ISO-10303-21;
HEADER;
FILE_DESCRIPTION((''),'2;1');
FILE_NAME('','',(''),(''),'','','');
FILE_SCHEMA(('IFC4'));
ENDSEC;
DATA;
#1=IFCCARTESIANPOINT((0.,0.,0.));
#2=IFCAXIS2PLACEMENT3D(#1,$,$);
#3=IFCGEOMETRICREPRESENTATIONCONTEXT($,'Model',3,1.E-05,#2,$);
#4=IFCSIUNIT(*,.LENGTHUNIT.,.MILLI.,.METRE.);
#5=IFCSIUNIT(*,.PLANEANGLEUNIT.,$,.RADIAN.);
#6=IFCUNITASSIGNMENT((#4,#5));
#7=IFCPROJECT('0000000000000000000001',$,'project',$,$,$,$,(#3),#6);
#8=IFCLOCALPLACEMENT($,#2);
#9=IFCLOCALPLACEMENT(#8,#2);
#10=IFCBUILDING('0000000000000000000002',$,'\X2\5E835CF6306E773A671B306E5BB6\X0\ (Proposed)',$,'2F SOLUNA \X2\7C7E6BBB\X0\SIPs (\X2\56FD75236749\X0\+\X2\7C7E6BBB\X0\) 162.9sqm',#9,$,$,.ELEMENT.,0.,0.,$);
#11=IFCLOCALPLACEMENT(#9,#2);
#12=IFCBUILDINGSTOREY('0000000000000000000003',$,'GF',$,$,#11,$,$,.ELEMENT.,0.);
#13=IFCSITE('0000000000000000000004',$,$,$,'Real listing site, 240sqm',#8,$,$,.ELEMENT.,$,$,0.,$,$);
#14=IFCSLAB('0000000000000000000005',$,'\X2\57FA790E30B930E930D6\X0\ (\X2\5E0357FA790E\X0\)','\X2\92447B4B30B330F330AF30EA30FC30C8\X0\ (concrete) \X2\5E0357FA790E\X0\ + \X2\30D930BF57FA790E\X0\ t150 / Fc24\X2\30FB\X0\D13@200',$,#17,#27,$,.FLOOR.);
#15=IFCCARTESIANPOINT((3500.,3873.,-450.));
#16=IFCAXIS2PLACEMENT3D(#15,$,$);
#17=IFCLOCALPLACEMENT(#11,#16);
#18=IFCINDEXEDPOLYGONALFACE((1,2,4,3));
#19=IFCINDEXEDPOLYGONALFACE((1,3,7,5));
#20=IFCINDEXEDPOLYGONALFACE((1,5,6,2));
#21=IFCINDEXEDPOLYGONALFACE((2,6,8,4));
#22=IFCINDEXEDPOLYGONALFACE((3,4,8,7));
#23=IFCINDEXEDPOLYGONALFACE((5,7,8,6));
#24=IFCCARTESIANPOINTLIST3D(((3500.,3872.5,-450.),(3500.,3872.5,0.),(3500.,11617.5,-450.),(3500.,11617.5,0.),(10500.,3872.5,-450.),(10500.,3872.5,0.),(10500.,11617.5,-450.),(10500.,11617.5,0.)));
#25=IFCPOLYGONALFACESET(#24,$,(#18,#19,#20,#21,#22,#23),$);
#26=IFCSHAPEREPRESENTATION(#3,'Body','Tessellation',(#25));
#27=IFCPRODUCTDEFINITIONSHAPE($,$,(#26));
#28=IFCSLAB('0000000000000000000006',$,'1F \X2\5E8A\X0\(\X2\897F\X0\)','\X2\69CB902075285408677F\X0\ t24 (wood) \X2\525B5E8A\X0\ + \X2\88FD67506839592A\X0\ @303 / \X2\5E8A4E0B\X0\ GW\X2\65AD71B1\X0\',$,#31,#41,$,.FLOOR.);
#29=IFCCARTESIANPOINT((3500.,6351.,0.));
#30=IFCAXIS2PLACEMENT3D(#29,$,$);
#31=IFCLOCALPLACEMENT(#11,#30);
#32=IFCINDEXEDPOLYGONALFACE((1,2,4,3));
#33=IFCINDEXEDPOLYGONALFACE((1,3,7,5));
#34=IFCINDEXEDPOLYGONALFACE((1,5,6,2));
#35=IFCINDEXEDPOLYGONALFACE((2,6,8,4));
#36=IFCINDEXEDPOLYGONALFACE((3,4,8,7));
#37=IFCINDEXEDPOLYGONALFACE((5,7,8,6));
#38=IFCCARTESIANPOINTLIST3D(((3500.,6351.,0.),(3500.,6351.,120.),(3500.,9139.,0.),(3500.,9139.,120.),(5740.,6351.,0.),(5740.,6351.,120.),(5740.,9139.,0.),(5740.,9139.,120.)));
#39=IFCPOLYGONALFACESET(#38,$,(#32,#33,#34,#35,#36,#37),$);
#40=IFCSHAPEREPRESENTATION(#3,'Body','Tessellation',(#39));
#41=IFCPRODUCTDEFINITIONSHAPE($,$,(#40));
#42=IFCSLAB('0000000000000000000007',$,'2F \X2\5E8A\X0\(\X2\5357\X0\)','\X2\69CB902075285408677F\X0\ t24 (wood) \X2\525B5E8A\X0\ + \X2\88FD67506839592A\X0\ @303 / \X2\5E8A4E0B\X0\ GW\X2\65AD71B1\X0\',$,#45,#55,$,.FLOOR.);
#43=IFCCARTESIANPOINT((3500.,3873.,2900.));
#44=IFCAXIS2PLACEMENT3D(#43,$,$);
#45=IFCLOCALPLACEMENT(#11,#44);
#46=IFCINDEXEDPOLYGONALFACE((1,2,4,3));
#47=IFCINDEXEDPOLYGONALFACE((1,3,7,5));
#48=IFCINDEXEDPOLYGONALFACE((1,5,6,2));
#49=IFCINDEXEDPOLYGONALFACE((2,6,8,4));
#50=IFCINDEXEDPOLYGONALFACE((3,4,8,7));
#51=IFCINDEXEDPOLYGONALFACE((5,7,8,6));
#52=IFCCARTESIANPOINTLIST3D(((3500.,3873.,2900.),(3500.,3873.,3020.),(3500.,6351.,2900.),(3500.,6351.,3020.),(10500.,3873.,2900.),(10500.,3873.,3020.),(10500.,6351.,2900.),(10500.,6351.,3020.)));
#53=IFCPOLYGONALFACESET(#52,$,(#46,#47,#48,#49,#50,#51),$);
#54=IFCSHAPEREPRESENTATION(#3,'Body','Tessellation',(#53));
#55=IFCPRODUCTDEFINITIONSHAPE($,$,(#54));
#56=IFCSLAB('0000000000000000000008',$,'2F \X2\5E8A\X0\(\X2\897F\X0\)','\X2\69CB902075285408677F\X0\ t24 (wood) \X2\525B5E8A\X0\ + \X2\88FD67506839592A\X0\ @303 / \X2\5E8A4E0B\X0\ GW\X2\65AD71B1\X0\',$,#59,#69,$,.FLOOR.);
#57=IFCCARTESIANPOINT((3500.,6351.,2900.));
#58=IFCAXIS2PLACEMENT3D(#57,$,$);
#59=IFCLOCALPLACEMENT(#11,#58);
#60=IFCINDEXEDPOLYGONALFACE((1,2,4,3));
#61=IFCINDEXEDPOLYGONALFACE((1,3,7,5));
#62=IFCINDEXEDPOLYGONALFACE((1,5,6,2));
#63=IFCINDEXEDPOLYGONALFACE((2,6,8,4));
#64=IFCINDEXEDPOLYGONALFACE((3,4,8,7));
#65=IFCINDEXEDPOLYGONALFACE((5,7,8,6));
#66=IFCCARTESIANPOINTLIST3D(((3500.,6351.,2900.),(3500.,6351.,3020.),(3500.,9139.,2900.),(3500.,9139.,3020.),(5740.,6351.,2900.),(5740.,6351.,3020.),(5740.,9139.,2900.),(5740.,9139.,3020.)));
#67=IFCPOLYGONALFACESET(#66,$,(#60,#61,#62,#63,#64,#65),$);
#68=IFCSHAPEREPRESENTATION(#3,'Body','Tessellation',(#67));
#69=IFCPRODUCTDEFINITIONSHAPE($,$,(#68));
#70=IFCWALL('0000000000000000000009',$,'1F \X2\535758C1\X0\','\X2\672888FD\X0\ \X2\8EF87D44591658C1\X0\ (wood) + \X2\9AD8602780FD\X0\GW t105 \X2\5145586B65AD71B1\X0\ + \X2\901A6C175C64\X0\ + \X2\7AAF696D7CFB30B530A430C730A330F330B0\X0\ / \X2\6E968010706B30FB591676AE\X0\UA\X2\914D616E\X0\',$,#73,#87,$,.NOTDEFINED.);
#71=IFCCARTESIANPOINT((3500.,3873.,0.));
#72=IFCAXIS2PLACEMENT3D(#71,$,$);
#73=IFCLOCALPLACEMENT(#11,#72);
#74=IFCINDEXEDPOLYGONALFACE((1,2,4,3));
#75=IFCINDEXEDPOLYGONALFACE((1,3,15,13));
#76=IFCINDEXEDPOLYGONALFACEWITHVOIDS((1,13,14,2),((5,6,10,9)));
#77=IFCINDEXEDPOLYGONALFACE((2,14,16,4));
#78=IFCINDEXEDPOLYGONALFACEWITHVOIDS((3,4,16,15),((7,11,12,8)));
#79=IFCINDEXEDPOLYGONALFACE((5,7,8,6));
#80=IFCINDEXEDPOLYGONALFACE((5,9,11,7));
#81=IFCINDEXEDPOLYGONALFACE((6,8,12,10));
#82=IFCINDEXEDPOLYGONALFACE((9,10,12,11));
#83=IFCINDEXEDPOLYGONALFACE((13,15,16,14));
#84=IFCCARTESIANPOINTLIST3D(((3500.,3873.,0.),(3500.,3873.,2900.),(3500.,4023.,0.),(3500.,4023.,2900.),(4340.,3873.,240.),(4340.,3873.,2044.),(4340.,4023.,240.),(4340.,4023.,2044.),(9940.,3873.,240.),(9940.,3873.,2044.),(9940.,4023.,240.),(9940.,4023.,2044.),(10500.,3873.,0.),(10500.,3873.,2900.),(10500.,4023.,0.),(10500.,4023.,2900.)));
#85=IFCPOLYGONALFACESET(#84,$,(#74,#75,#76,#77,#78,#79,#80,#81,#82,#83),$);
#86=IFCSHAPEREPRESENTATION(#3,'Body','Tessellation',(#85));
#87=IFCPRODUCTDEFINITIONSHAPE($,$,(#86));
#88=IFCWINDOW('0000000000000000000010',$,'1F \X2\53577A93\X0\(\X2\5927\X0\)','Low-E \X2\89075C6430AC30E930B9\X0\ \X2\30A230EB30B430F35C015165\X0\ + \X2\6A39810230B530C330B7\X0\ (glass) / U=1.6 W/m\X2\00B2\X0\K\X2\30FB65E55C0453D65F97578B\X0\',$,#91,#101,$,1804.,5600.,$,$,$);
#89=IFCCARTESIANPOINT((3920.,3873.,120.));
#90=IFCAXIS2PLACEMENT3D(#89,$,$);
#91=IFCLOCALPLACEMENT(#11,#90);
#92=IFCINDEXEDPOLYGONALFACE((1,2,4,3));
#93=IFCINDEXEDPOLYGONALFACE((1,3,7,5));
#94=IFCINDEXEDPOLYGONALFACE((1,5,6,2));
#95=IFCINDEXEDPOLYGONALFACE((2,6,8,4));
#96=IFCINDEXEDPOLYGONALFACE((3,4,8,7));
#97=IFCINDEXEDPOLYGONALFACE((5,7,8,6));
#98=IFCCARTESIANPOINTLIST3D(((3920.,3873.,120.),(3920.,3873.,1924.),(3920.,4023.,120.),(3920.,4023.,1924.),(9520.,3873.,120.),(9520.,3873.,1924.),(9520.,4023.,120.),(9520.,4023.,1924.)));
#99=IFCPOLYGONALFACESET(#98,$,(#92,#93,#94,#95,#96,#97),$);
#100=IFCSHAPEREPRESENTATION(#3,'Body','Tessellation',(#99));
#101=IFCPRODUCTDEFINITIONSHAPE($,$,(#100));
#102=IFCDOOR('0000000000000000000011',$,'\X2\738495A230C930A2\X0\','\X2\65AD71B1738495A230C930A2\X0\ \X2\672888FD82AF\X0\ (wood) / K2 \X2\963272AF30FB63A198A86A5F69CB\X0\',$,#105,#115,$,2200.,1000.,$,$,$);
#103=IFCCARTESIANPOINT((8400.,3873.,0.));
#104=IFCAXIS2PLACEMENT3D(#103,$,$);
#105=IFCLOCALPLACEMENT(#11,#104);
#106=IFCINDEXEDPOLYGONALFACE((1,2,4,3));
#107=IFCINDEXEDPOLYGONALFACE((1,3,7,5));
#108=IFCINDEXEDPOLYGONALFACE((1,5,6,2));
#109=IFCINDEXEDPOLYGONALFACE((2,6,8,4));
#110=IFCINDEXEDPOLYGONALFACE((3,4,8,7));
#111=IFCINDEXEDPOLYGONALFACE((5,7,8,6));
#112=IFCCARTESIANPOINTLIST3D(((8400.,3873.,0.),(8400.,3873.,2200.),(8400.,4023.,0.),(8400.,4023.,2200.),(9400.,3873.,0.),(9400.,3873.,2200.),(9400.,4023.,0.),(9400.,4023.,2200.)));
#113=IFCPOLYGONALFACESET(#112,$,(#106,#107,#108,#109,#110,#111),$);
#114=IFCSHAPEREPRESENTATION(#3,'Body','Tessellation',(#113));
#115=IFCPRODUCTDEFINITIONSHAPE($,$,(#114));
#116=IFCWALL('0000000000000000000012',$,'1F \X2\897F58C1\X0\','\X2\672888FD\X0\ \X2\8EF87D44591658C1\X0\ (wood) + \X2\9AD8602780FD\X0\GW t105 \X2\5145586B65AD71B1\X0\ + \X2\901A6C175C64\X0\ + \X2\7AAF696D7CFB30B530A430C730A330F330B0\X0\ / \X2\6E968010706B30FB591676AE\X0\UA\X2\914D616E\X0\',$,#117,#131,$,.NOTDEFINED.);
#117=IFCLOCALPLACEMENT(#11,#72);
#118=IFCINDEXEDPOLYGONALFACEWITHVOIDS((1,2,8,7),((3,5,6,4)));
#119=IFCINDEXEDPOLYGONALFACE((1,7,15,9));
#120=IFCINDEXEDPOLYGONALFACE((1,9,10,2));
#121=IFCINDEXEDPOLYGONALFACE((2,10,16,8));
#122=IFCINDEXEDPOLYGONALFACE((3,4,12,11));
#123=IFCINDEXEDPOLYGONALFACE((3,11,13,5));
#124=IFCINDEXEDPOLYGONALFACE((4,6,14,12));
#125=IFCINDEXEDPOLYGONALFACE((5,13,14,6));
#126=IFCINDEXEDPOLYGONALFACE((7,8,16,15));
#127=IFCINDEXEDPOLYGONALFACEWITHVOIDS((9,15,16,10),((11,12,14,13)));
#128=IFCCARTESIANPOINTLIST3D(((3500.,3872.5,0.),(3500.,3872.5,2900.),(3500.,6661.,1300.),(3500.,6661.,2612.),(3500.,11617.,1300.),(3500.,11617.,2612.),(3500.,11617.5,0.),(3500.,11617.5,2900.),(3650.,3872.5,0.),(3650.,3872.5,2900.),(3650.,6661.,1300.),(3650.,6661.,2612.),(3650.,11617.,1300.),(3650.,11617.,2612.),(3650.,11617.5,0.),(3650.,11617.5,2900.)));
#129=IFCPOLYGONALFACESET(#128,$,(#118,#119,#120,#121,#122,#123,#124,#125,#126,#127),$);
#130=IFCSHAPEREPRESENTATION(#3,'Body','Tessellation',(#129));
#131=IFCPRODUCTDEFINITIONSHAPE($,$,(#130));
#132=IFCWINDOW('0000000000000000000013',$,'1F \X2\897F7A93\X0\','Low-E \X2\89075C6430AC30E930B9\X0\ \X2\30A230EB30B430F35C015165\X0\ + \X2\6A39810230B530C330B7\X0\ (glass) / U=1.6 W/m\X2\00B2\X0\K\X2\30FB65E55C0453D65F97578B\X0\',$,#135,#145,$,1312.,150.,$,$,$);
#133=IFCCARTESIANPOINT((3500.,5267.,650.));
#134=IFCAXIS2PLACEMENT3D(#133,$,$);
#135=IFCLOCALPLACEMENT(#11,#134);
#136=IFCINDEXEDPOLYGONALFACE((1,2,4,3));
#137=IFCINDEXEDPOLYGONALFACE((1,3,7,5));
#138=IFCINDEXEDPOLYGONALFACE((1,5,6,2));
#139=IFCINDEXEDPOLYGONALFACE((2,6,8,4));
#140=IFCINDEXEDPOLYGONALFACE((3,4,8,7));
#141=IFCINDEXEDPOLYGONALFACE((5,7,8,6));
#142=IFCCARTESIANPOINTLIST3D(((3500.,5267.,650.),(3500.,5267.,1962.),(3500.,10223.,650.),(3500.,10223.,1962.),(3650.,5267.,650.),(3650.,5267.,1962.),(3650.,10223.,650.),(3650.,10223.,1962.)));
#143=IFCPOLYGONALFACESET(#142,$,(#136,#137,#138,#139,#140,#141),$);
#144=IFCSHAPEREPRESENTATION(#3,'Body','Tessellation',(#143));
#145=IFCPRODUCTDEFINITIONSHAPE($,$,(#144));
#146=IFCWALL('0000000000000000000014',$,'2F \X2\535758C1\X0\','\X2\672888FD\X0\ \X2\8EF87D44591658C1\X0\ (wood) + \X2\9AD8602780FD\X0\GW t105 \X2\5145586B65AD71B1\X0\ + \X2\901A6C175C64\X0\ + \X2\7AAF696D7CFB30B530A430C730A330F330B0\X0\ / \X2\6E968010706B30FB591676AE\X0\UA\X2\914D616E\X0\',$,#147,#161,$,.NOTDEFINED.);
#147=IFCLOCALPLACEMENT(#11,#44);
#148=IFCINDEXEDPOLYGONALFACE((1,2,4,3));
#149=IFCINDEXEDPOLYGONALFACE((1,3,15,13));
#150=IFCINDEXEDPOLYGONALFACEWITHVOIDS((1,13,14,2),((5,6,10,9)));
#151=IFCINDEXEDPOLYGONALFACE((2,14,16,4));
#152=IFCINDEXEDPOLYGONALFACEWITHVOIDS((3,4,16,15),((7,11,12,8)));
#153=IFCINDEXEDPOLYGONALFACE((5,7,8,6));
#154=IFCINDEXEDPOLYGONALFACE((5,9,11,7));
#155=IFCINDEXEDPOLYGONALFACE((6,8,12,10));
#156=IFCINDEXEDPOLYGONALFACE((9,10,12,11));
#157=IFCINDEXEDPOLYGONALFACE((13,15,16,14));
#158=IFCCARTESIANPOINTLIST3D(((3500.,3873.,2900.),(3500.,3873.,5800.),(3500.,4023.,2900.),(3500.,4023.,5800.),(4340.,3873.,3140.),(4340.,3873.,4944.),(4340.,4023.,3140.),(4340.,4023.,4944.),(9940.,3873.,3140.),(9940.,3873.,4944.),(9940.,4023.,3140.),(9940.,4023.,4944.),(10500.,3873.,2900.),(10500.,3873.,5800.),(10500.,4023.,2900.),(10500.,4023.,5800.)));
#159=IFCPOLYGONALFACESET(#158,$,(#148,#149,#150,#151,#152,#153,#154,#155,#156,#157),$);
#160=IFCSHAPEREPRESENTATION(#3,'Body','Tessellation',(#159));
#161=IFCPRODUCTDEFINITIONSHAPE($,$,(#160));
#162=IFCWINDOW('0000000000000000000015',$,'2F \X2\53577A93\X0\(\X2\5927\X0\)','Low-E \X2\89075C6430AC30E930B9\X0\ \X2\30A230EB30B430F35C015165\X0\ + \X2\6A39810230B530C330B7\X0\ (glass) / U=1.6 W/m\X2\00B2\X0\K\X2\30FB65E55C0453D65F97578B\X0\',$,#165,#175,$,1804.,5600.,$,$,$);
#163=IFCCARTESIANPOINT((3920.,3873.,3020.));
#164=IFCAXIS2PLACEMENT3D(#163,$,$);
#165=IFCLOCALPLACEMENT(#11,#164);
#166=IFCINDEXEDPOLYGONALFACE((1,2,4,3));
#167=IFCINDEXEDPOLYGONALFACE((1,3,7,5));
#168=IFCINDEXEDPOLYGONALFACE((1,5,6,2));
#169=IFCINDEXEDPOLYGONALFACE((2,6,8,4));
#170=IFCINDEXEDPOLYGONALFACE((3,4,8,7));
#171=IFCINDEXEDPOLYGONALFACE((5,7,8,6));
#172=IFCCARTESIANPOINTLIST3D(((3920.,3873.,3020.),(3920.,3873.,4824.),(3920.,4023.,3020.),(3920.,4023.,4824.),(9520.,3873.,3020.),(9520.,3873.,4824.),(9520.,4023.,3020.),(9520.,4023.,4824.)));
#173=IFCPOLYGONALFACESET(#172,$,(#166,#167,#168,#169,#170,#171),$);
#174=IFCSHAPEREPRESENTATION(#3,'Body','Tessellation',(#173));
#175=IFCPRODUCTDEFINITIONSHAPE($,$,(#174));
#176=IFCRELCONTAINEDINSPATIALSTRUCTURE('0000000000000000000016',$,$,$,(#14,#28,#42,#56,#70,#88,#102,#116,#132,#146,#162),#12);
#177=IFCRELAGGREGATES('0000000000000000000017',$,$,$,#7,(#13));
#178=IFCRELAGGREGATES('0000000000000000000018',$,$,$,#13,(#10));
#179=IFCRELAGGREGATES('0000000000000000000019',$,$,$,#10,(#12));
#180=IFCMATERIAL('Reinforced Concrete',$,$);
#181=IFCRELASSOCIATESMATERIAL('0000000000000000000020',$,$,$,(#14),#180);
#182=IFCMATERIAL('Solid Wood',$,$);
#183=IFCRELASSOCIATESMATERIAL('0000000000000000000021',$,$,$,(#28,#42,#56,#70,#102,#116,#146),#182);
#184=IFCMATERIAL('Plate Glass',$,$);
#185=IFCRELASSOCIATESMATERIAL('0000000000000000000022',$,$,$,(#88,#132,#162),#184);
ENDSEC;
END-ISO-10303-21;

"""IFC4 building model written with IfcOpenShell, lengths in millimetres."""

from ifc_helpers import new_model, si_unit, frame, frame_2d, origin, place, context, project, spatial, rectangle, extrude, material, element, fill, save


model = new_model("IFC4")

# Units and contexts
model_context = context("Model", 3, precision=1e-05, world=origin())
ifc_project = project(units=[si_unit("LENGTHUNIT", "METRE", prefix="MILLI"), si_unit("PLANEANGLEUNIT", "RADIAN")], contexts=[model_context])

# Site, building, storey
site_placement = place(None, origin())
site = spatial("IfcSite", under=ifc_project, at=site_placement, ObjectType="Real listing site, 240sqm", CompositionType="ELEMENT", RefElevation=0.0)
building_placement = place(site_placement, origin())
building = spatial("IfcBuilding", under=site, at=building_placement, Name="広島の眺望の家 (Proposed)", ObjectType="2F SOLUNA 籾殻SIPs (国産杉+籾殻) 162.9sqm", CompositionType="ELEMENT", ElevationOfRefHeight=0.0, ElevationOfTerrain=0.0)
storey_placement = place(building_placement, origin())
storey = spatial("IfcBuildingStorey", under=building, at=storey_placement, Name="GF", CompositionType="ELEMENT", Elevation=0.0)

# Slabs
ifc_material_1 = material(Name="Reinforced Concrete")
slab_1_placement = place(storey_placement, frame((3500.0, 3873.0, -450.0)))
element("IfcSlab", 1, at=slab_1_placement, inside=storey, material=ifc_material_1, Name="基礎スラブ (布基礎)", Description="鉄筋コンクリート (concrete) 布基礎 + ベタ基礎 t150 / Fc24・D13@200", PredefinedType="FLOOR", context=model_context, shape_type="SweptSolid", body=[
    extrude(rectangle(XDim=7000.0, YDim=7745.0, at=frame_2d((3500.0, 3872.0))), frame((3500.0, 3873.0, -450.0)), (0.0, 0.0, 1.0), 450.0),
])
ifc_material_2 = material(Name="Solid Wood")
slab_2_placement = place(storey_placement, frame((3500.0, 6351.0, 0.0)))
element("IfcSlab", 2, at=slab_2_placement, inside=storey, material=ifc_material_2, Name="1F 床(西)", Description="構造用合板 t24 (wood) 剛床 + 製材根太 @303 / 床下 GW断熱", PredefinedType="FLOOR", context=model_context, shape_type="SweptSolid", body=[
    extrude(rectangle(XDim=2240.0, YDim=2788.0, at=frame_2d((1120.0, 1394.0))), frame((3500.0, 6351.0, 0.0)), (0.0, 0.0, 1.0), 120.0),
])
slab_3_placement = place(storey_placement, frame((3500.0, 3873.0, 2900.0)))
element("IfcSlab", 3, at=slab_3_placement, inside=storey, material=ifc_material_2, Name="2F 床(南)", Description="構造用合板 t24 (wood) 剛床 + 製材根太 @303 / 床下 GW断熱", PredefinedType="FLOOR", context=model_context, shape_type="SweptSolid", body=[
    extrude(rectangle(XDim=7000.0, YDim=2478.0, at=frame_2d((3500.0, 1239.0))), frame((3500.0, 3873.0, 2900.0)), (0.0, 0.0, 1.0), 120.0),
])
slab_4_placement = place(storey_placement, frame((3500.0, 6351.0, 2900.0)))
element("IfcSlab", 4, at=slab_4_placement, inside=storey, material=ifc_material_2, Name="2F 床(西)", Description="構造用合板 t24 (wood) 剛床 + 製材根太 @303 / 床下 GW断熱", PredefinedType="FLOOR", context=model_context, shape_type="SweptSolid", body=[
    extrude(rectangle(XDim=2240.0, YDim=2788.0, at=frame_2d((1120.0, 1394.0))), frame((3500.0, 6351.0, 2900.0)), (0.0, 0.0, 1.0), 120.0),
])

# Wall, openings, window, door
wall_1_placement = place(storey_placement, frame((3500.0, 3873.0, 0.0)))
wall_1 = element("IfcWall", 5, at=wall_1_placement, inside=storey, material=ifc_material_2, Name="1F 南壁", Description="木製 軸組外壁 (wood) + 高性能GW t105 充填断熱 + 通気層 + 窯業系サイディング / 準耐火・外皮UA配慮", PredefinedType="NOTDEFINED", context=model_context, shape_type="SweptSolid", body=[
    extrude(rectangle(XDim=7000.0, YDim=150.0, at=frame_2d((3500.0, 75.0))), frame((3500.0, 3873.0, 0.0)), (0.0, 0.0, 1.0), 2900.0),
])
opening_1_placement = place(storey_placement, frame((3920.0, 3873.0, 120.0)))
opening_1 = element("IfcOpeningElement", 6, at=opening_1_placement, cuts=wall_1, PredefinedType="NOTDEFINED", context=model_context, shape_type="SweptSolid", body=[
    extrude(rectangle(XDim=5600.0, YDim=150.0, at=frame_2d((2800.0, 75.0))), frame((3920.0, 3873.0, 120.0)), (0.0, 0.0, 1.0), 1804.0),
])
opening_2_placement = place(storey_placement, frame((8400.0, 3873.0, 0.0)))
opening_2 = element("IfcOpeningElement", 7, at=opening_2_placement, cuts=wall_1, PredefinedType="NOTDEFINED", context=model_context, shape_type="SweptSolid", body=[
    extrude(rectangle(XDim=1000.0, YDim=150.0, at=frame_2d((500.0, 75.0))), frame((8400.0, 3873.0, 0.0)), (0.0, 0.0, 1.0), 2200.0),
])
ifc_material_3 = material(Name="Plate Glass")
window_1_placement = place(storey_placement, frame((3920.0, 3873.0, 120.0)))
window_1 = element("IfcWindow", 8, at=window_1_placement, inside=storey, material=ifc_material_3, Name="1F 南窓(大)", Description="Low-E 複層ガラス アルゴン封入 + 樹脂サッシ (glass) / U=1.6 W/m²K・日射取得型", OverallHeight=1804.0, OverallWidth=5600.0, context=model_context, shape_type="SweptSolid", body=[
    extrude(rectangle(XDim=5600.0, YDim=150.0, at=frame_2d((2800.0, 75.0))), frame((3920.0, 3873.0, 120.0)), (0.0, 0.0, 1.0), 1804.0),
])
fill(opening_1, window_1)
door_placement = place(storey_placement, frame((8400.0, 3873.0, 0.0)))
door = element("IfcDoor", 9, at=door_placement, inside=storey, material=ifc_material_2, Name="玄関ドア", Description="断熱玄関ドア 木製芯 (wood) / K2 防犯・採風機構", OverallHeight=2200.0, OverallWidth=1000.0, context=model_context, shape_type="SweptSolid", body=[
    extrude(rectangle(XDim=1000.0, YDim=150.0, at=frame_2d((500.0, 75.0))), frame((8400.0, 3873.0, 0.0)), (0.0, 0.0, 1.0), 2200.0),
])
fill(opening_2, door)

# Walls, openings, windows
wall_2_placement = place(storey_placement, frame((3500.0, 3873.0, 0.0)))
wall_2 = element("IfcWall", 10, at=wall_2_placement, inside=storey, material=ifc_material_2, Name="1F 西壁", Description="木製 軸組外壁 (wood) + 高性能GW t105 充填断熱 + 通気層 + 窯業系サイディング / 準耐火・外皮UA配慮", PredefinedType="NOTDEFINED", context=model_context, shape_type="SweptSolid", body=[
    extrude(rectangle(XDim=150.0, YDim=7745.0, at=frame_2d((75.0, 3872.0))), frame((3500.0, 3873.0, 0.0)), (0.0, 0.0, 1.0), 2900.0),
])
opening_3_placement = place(storey_placement, frame((3500.0, 5267.0, 650.0)))
opening_3 = element("IfcOpeningElement", 11, at=opening_3_placement, cuts=wall_2, PredefinedType="NOTDEFINED", context=model_context, shape_type="SweptSolid", body=[
    extrude(rectangle(XDim=150.0, YDim=4956.0, at=frame_2d((75.0, 2478.0))), frame((3500.0, 5267.0, 650.0)), (0.0, 0.0, 1.0), 1312.0),
])
window_2_placement = place(storey_placement, frame((3500.0, 5267.0, 650.0)))
window_2 = element("IfcWindow", 12, at=window_2_placement, inside=storey, material=ifc_material_3, Name="1F 西窓", Description="Low-E 複層ガラス アルゴン封入 + 樹脂サッシ (glass) / U=1.6 W/m²K・日射取得型", OverallHeight=1312.0, OverallWidth=150.0, context=model_context, shape_type="SweptSolid", body=[
    extrude(rectangle(XDim=150.0, YDim=4956.0, at=frame_2d((75.0, 2478.0))), frame((3500.0, 5267.0, 650.0)), (0.0, 0.0, 1.0), 1312.0),
])
fill(opening_3, window_2)
wall_3_placement = place(storey_placement, frame((3500.0, 3873.0, 2900.0)))
wall_3 = element("IfcWall", 13, at=wall_3_placement, inside=storey, material=ifc_material_2, Name="2F 南壁", Description="木製 軸組外壁 (wood) + 高性能GW t105 充填断熱 + 通気層 + 窯業系サイディング / 準耐火・外皮UA配慮", PredefinedType="NOTDEFINED", context=model_context, shape_type="SweptSolid", body=[
    extrude(rectangle(XDim=7000.0, YDim=150.0, at=frame_2d((3500.0, 75.0))), frame((3500.0, 3873.0, 2900.0)), (0.0, 0.0, 1.0), 2900.0),
])
opening_4_placement = place(storey_placement, frame((3920.0, 3873.0, 3020.0)))
opening_4 = element("IfcOpeningElement", 14, at=opening_4_placement, cuts=wall_3, PredefinedType="NOTDEFINED", context=model_context, shape_type="SweptSolid", body=[
    extrude(rectangle(XDim=5600.0, YDim=150.0, at=frame_2d((2800.0, 75.0))), frame((3920.0, 3873.0, 3020.0)), (0.0, 0.0, 1.0), 1804.0),
])
window_3_placement = place(storey_placement, frame((3920.0, 3873.0, 3020.0)))
window_3 = element("IfcWindow", 15, at=window_3_placement, inside=storey, material=ifc_material_3, Name="2F 南窓(大)", Description="Low-E 複層ガラス アルゴン封入 + 樹脂サッシ (glass) / U=1.6 W/m²K・日射取得型", OverallHeight=1804.0, OverallWidth=5600.0, context=model_context, shape_type="SweptSolid", body=[
    extrude(rectangle(XDim=5600.0, YDim=150.0, at=frame_2d((2800.0, 75.0))), frame((3920.0, 3873.0, 3020.0)), (0.0, 0.0, 1.0), 1804.0),
])
fill(opening_4, window_3)

save(model, "model.ifc")
